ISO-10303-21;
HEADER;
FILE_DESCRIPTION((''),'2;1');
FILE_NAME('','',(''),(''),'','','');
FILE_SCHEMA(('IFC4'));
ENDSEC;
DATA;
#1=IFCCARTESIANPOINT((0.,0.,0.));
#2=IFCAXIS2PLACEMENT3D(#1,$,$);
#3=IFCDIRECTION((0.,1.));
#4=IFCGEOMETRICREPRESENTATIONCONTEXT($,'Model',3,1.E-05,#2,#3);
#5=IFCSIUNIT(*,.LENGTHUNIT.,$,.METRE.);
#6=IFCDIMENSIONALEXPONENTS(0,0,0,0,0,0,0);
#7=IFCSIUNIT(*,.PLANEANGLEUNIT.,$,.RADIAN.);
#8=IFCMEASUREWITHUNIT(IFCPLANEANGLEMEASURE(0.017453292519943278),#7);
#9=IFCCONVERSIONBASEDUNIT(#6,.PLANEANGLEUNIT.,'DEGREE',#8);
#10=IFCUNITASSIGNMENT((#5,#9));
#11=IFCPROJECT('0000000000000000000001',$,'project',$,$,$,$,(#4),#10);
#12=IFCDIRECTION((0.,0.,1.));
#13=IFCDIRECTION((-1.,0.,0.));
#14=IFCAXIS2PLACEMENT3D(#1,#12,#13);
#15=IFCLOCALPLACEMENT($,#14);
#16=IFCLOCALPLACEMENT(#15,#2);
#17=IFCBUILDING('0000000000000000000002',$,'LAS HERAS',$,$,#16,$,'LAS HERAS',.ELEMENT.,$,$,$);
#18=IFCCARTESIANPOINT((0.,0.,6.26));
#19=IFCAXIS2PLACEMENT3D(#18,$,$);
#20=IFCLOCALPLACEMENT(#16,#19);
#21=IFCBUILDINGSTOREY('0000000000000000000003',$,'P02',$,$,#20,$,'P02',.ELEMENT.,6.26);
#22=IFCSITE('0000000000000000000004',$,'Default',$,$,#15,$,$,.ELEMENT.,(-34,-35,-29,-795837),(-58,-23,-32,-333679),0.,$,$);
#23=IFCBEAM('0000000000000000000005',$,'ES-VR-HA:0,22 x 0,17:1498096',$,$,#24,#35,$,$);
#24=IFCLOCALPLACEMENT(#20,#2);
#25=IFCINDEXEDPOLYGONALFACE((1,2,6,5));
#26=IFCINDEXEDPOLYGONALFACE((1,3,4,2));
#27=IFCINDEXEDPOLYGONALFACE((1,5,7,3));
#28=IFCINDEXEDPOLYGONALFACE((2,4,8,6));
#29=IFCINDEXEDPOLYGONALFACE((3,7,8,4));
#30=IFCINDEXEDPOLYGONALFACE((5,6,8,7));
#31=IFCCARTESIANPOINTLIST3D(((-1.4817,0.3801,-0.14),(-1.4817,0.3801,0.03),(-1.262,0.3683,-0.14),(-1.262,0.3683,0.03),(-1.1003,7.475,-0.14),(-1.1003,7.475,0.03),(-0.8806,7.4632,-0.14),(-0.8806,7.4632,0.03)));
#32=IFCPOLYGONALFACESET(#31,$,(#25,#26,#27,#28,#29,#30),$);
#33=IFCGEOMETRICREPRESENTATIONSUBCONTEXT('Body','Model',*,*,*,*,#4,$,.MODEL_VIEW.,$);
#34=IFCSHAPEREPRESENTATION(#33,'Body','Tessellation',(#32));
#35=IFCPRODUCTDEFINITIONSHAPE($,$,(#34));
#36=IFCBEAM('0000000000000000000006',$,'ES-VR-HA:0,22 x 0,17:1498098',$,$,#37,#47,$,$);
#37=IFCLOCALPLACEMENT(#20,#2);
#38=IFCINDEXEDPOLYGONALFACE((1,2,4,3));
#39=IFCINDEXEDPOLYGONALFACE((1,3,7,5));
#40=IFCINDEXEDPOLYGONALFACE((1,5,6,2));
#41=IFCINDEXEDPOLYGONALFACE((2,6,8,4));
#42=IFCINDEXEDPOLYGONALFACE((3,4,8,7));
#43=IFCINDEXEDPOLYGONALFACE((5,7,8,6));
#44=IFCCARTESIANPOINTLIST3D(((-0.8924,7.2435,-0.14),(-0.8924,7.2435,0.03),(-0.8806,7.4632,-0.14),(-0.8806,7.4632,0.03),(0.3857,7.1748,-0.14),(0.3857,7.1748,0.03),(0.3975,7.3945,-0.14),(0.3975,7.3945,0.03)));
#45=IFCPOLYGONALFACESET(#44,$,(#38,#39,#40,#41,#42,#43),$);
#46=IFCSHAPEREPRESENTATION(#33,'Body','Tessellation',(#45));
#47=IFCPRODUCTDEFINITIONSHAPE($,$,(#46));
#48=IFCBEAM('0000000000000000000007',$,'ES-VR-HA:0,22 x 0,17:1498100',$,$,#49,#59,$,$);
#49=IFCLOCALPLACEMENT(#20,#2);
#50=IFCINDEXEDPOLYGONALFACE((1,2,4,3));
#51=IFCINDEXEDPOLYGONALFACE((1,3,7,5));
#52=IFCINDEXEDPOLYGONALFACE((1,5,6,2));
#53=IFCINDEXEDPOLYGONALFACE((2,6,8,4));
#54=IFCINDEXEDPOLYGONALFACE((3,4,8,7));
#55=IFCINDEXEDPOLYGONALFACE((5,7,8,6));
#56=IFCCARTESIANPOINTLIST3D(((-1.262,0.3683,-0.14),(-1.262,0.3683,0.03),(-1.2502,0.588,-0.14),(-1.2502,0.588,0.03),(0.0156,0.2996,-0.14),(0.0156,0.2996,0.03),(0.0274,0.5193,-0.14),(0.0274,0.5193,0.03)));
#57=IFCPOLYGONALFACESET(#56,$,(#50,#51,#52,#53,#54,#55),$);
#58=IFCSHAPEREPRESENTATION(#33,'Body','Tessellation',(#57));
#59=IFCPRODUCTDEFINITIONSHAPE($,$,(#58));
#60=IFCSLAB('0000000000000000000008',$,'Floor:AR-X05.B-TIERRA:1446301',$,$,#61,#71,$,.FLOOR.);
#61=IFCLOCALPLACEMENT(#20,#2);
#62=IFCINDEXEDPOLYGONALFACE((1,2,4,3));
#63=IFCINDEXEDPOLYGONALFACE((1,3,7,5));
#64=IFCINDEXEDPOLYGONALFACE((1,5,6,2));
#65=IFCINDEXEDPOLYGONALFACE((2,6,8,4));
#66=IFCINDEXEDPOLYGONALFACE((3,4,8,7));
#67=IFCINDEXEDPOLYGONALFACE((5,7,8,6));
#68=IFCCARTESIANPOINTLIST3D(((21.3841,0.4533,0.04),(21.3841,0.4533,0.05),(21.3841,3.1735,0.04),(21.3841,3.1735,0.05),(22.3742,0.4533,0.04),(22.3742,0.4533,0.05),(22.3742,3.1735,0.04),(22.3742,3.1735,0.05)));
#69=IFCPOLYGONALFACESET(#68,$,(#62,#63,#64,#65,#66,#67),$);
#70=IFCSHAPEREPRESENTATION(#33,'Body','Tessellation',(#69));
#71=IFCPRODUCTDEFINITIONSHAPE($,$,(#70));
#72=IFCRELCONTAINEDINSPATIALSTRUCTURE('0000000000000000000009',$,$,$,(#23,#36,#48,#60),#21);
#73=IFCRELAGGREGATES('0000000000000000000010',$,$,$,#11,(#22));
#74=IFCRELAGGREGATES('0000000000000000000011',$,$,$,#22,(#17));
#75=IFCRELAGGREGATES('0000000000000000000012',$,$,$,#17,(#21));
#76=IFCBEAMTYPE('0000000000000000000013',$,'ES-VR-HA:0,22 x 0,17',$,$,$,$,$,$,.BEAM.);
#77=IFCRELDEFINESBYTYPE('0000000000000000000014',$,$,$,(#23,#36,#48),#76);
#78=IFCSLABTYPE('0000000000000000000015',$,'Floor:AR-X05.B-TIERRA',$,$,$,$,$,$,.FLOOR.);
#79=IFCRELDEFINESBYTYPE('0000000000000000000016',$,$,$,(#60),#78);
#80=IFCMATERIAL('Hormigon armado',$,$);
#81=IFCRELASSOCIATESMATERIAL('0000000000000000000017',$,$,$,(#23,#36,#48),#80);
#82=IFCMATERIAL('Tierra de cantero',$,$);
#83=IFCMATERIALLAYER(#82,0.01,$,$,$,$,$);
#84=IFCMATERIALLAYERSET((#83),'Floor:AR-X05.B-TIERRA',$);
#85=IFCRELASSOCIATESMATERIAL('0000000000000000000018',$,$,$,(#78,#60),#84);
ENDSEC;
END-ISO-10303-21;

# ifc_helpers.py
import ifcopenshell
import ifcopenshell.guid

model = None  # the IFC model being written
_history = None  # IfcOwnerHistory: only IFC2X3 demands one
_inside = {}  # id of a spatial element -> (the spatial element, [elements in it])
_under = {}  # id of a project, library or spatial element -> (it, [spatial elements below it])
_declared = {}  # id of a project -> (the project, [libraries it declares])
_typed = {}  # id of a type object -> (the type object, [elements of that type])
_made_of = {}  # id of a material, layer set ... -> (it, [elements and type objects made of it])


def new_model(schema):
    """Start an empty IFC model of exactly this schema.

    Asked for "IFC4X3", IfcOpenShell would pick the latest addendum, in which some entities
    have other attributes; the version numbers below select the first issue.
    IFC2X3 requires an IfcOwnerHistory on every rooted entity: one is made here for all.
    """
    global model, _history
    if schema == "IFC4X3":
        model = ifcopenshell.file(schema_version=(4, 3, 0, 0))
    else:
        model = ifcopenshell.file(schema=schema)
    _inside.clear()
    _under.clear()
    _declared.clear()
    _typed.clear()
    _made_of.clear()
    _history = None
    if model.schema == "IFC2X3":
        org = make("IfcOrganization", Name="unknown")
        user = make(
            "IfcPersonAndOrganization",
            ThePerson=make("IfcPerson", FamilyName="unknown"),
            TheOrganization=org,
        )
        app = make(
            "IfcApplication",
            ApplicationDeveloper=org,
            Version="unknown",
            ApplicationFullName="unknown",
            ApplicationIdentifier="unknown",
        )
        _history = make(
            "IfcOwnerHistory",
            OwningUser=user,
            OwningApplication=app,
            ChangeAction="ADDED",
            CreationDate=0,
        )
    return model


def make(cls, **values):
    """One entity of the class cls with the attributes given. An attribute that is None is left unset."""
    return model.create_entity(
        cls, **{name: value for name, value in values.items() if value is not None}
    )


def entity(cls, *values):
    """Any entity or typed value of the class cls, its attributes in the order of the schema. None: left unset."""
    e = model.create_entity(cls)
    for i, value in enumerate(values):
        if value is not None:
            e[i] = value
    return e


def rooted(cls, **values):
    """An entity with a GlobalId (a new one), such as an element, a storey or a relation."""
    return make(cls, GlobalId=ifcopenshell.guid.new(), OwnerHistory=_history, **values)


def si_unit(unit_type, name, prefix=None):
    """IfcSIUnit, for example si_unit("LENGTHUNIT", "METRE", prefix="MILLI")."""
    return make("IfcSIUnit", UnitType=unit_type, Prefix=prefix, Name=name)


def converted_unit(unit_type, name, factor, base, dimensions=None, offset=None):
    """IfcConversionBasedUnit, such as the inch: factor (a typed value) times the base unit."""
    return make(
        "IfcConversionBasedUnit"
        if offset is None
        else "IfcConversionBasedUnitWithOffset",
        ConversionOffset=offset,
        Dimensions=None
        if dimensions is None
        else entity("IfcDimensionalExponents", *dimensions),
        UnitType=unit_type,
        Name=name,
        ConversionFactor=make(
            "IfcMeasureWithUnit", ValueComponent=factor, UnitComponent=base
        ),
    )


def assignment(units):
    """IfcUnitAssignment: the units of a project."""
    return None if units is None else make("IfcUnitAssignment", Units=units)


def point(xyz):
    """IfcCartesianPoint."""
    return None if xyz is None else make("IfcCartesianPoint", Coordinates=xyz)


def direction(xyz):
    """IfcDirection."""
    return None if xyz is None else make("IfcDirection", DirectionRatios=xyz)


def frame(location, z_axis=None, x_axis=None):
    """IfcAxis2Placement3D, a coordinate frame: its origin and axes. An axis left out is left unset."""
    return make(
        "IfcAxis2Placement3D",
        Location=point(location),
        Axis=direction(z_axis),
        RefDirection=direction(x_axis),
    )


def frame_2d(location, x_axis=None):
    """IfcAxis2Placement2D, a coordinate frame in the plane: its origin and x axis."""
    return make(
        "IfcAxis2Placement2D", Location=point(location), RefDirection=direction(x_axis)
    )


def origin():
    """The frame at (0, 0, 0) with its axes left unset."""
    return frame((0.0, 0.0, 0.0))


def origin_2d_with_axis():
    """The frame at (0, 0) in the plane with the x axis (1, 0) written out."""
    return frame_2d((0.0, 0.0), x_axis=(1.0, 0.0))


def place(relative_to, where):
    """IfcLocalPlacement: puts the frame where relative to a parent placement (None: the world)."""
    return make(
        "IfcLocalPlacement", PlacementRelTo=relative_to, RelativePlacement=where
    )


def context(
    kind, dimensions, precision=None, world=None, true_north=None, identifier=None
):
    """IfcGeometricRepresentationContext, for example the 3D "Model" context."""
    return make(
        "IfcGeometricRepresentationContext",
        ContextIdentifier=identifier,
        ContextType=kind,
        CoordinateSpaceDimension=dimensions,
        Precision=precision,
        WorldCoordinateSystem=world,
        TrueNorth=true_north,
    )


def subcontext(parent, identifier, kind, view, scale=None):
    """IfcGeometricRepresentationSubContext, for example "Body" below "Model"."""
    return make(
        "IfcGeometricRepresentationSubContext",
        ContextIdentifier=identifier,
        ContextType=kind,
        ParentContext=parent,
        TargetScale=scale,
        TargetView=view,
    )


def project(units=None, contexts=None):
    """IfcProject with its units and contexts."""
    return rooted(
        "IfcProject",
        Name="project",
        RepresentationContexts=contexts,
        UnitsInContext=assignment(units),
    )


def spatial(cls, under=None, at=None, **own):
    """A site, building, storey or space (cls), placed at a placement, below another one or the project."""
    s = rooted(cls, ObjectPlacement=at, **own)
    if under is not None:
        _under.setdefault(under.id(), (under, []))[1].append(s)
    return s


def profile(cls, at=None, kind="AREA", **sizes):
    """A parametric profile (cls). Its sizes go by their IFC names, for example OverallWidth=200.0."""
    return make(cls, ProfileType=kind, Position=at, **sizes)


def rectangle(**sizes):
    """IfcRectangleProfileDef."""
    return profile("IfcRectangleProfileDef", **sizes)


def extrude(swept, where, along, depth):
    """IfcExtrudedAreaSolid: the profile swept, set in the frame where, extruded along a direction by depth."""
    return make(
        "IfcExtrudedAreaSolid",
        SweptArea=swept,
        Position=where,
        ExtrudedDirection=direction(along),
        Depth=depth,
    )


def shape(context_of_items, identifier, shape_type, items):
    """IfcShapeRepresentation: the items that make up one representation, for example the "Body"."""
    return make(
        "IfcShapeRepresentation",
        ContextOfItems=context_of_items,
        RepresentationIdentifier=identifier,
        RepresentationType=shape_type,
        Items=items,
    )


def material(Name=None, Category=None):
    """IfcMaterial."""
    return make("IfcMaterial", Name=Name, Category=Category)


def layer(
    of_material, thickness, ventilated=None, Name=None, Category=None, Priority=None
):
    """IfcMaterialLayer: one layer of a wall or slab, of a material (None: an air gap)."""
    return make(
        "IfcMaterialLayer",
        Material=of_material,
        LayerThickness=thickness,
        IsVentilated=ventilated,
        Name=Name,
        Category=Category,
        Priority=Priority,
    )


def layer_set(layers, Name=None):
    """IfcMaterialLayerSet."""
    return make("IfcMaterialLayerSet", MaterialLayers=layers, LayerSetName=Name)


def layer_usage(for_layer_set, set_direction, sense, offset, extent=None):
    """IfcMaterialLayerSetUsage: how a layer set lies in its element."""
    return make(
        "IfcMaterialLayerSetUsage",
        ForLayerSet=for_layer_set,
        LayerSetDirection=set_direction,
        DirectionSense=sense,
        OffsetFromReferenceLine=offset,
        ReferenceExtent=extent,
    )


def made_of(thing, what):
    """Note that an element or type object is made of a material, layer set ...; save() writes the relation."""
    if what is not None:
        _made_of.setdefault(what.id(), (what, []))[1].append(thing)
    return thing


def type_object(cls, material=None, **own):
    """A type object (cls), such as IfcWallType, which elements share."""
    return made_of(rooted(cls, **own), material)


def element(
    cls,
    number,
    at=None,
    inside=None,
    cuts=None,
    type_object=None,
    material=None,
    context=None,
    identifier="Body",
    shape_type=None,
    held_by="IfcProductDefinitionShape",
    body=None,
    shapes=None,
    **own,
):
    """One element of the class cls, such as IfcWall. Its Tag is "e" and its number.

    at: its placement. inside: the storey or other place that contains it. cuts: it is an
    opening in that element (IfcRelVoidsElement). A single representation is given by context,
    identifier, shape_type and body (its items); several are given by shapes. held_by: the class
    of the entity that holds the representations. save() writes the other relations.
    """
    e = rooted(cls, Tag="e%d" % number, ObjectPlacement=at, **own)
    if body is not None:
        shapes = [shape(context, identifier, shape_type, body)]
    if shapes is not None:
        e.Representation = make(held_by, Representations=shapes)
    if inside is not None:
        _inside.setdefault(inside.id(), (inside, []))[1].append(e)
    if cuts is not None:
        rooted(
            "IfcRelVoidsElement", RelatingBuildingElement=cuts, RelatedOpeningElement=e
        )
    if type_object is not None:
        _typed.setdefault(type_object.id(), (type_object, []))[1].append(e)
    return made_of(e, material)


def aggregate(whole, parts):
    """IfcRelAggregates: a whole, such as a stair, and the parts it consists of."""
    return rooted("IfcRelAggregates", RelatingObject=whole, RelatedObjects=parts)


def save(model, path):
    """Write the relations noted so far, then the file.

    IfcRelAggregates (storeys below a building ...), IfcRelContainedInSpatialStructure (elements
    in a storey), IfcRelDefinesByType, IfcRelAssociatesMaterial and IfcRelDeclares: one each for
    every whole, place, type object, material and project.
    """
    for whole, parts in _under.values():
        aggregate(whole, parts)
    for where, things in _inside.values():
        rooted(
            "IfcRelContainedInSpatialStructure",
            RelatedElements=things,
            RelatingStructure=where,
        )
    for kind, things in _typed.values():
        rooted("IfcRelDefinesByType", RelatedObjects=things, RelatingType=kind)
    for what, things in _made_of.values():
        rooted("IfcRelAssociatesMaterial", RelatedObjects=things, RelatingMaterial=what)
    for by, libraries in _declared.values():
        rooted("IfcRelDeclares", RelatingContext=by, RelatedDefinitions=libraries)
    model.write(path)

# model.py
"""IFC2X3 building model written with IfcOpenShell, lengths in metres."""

from ifc_helpers import new_model, entity, si_unit, converted_unit, direction, frame, frame_2d, origin, origin_2d_with_axis, place, context, subcontext, project, spatial, rectangle, extrude, material, layer, layer_set, layer_usage, type_object, element, save


model = new_model("IFC2X3")

# Units and contexts
model_context = context("Model", 3, precision=1e-05, world=origin(), true_north=direction((0.0, 1.0)))
body_context = subcontext(model_context, "Body", "Model", "MODEL_VIEW")
ifc_project = project(units=[si_unit("LENGTHUNIT", "METRE"), converted_unit("PLANEANGLEUNIT", "DEGREE", entity("IfcPlaneAngleMeasure", 0.017453292519943278), si_unit("PLANEANGLEUNIT", "RADIAN"), dimensions=[0, 0, 0, 0, 0, 0, 0])], contexts=[model_context])

# Site, building, storey
site_placement = place(None, frame((0.0, 0.0, 0.0), z_axis=(0.0, 0.0, 1.0), x_axis=(-1.0, 0.0, 0.0)))
site = spatial("IfcSite", under=ifc_project, at=site_placement, Name="Default", CompositionType="ELEMENT", RefLatitude=(-34, -35, -29, -795837), RefLongitude=(-58, -23, -32, -333679), RefElevation=0.0)
building_placement = place(site_placement, origin())
building = spatial("IfcBuilding", under=site, at=building_placement, Name="LAS HERAS", LongName="LAS HERAS", CompositionType="ELEMENT")
storey_placement = place(building_placement, frame((0.0, 0.0, 6.26)))
storey = spatial("IfcBuildingStorey", under=building, at=storey_placement, Name="P02", LongName="P02", CompositionType="ELEMENT", Elevation=6.26)

# Beams
ifc_material_1 = material(Name="Hormigon armado")
beam_type = type_object("IfcBeamType", Name="ES-VR-HA:0,22 x 0,17", PredefinedType="BEAM")
beam_1_placement = place(storey_placement, frame((-0.9963, 7.3593, 0.03), z_axis=(0.0, 0.0, 1.0), x_axis=(-0.05369, -0.998558, 0.0)))
element("IfcBeam", 1, at=beam_1_placement, inside=storey, type_object=beam_type, material=ifc_material_1, Name="ES-VR-HA:0,22 x 0,17:1498096", context=body_context, shape_type="SweptSolid", body=[
    extrude(rectangle(XDim=0.17, YDim=0.22, at=frame_2d((0.0, 0.0), x_axis=(1.0, 0.0))), frame((-0.11, 0.0, -0.085), z_axis=(1.0, 0.0, 0.0), x_axis=(0.0, 0.0, -1.0)), (0.0, 0.0, 1.0), 7.1052),
])
beam_2_placement = place(storey_placement, frame((0.3916, 7.2846, 0.03), z_axis=(0.0, 0.0, 1.0), x_axis=(-0.998558, 0.05368, 0.0)))
element("IfcBeam", 2, at=beam_2_placement, inside=storey, type_object=beam_type, material=ifc_material_1, Name="ES-VR-HA:0,22 x 0,17:1498098", context=body_context, shape_type="SweptSolid", body=[
    extrude(rectangle(XDim=0.17, YDim=0.22, at=frame_2d((0.0, 0.0), x_axis=(1.0, 0.0))), frame((0.0, 0.0, -0.085), z_axis=(1.0, 0.0, 0.0), x_axis=(0.0, 0.0, -1.0)), (0.0, 0.0, 1.0), 1.28),
])
beam_3_placement = place(storey_placement, frame((0.0215, 0.4094, 0.03), z_axis=(0.0, 0.0, 1.0), x_axis=(-0.998558, 0.05369, 0.0)))
element("IfcBeam", 3, at=beam_3_placement, inside=storey, type_object=beam_type, material=ifc_material_1, Name="ES-VR-HA:0,22 x 0,17:1498100", context=body_context, shape_type="SweptSolid", body=[
    extrude(rectangle(XDim=0.17, YDim=0.22, at=origin_2d_with_axis()), frame((0.0, 0.0, -0.085), z_axis=(1.0, 0.0, 0.0), x_axis=(0.0, 0.0, -1.0)), (0.0, 0.0, 1.0), 1.2795),
])

# Slab
ifc_material_2 = material(Name="Tierra de cantero")
ifc_layer = layer(ifc_material_2, 0.01)
ifc_layer_set = layer_set([ifc_layer], Name="Floor:AR-X05.B-TIERRA")
ifc_layer_usage = layer_usage(ifc_layer_set, "AXIS3", "POSITIVE", 0.0)
slab_type = type_object("IfcSlabType", Name="Floor:AR-X05.B-TIERRA", PredefinedType="FLOOR", material=ifc_layer_set)
slab_placement = place(storey_placement, origin())
element("IfcSlab", 4, at=slab_placement, inside=storey, type_object=slab_type, material=ifc_layer_usage, Name="Floor:AR-X05.B-TIERRA:1446301", PredefinedType="FLOOR", context=body_context, shape_type="SweptSolid", body=[
    extrude(rectangle(XDim=2.7202, YDim=0.9901, at=frame_2d((0.0, 0.0), x_axis=(1.0, 0.0))), frame((21.8791, 1.8134, 0.05), z_axis=(0.0, 0.0, -1.0), x_axis=(0.0, 1.0, 0.0)), (0.0, 0.0, 1.0), 0.01),
])

save(model, "model.ifc")
